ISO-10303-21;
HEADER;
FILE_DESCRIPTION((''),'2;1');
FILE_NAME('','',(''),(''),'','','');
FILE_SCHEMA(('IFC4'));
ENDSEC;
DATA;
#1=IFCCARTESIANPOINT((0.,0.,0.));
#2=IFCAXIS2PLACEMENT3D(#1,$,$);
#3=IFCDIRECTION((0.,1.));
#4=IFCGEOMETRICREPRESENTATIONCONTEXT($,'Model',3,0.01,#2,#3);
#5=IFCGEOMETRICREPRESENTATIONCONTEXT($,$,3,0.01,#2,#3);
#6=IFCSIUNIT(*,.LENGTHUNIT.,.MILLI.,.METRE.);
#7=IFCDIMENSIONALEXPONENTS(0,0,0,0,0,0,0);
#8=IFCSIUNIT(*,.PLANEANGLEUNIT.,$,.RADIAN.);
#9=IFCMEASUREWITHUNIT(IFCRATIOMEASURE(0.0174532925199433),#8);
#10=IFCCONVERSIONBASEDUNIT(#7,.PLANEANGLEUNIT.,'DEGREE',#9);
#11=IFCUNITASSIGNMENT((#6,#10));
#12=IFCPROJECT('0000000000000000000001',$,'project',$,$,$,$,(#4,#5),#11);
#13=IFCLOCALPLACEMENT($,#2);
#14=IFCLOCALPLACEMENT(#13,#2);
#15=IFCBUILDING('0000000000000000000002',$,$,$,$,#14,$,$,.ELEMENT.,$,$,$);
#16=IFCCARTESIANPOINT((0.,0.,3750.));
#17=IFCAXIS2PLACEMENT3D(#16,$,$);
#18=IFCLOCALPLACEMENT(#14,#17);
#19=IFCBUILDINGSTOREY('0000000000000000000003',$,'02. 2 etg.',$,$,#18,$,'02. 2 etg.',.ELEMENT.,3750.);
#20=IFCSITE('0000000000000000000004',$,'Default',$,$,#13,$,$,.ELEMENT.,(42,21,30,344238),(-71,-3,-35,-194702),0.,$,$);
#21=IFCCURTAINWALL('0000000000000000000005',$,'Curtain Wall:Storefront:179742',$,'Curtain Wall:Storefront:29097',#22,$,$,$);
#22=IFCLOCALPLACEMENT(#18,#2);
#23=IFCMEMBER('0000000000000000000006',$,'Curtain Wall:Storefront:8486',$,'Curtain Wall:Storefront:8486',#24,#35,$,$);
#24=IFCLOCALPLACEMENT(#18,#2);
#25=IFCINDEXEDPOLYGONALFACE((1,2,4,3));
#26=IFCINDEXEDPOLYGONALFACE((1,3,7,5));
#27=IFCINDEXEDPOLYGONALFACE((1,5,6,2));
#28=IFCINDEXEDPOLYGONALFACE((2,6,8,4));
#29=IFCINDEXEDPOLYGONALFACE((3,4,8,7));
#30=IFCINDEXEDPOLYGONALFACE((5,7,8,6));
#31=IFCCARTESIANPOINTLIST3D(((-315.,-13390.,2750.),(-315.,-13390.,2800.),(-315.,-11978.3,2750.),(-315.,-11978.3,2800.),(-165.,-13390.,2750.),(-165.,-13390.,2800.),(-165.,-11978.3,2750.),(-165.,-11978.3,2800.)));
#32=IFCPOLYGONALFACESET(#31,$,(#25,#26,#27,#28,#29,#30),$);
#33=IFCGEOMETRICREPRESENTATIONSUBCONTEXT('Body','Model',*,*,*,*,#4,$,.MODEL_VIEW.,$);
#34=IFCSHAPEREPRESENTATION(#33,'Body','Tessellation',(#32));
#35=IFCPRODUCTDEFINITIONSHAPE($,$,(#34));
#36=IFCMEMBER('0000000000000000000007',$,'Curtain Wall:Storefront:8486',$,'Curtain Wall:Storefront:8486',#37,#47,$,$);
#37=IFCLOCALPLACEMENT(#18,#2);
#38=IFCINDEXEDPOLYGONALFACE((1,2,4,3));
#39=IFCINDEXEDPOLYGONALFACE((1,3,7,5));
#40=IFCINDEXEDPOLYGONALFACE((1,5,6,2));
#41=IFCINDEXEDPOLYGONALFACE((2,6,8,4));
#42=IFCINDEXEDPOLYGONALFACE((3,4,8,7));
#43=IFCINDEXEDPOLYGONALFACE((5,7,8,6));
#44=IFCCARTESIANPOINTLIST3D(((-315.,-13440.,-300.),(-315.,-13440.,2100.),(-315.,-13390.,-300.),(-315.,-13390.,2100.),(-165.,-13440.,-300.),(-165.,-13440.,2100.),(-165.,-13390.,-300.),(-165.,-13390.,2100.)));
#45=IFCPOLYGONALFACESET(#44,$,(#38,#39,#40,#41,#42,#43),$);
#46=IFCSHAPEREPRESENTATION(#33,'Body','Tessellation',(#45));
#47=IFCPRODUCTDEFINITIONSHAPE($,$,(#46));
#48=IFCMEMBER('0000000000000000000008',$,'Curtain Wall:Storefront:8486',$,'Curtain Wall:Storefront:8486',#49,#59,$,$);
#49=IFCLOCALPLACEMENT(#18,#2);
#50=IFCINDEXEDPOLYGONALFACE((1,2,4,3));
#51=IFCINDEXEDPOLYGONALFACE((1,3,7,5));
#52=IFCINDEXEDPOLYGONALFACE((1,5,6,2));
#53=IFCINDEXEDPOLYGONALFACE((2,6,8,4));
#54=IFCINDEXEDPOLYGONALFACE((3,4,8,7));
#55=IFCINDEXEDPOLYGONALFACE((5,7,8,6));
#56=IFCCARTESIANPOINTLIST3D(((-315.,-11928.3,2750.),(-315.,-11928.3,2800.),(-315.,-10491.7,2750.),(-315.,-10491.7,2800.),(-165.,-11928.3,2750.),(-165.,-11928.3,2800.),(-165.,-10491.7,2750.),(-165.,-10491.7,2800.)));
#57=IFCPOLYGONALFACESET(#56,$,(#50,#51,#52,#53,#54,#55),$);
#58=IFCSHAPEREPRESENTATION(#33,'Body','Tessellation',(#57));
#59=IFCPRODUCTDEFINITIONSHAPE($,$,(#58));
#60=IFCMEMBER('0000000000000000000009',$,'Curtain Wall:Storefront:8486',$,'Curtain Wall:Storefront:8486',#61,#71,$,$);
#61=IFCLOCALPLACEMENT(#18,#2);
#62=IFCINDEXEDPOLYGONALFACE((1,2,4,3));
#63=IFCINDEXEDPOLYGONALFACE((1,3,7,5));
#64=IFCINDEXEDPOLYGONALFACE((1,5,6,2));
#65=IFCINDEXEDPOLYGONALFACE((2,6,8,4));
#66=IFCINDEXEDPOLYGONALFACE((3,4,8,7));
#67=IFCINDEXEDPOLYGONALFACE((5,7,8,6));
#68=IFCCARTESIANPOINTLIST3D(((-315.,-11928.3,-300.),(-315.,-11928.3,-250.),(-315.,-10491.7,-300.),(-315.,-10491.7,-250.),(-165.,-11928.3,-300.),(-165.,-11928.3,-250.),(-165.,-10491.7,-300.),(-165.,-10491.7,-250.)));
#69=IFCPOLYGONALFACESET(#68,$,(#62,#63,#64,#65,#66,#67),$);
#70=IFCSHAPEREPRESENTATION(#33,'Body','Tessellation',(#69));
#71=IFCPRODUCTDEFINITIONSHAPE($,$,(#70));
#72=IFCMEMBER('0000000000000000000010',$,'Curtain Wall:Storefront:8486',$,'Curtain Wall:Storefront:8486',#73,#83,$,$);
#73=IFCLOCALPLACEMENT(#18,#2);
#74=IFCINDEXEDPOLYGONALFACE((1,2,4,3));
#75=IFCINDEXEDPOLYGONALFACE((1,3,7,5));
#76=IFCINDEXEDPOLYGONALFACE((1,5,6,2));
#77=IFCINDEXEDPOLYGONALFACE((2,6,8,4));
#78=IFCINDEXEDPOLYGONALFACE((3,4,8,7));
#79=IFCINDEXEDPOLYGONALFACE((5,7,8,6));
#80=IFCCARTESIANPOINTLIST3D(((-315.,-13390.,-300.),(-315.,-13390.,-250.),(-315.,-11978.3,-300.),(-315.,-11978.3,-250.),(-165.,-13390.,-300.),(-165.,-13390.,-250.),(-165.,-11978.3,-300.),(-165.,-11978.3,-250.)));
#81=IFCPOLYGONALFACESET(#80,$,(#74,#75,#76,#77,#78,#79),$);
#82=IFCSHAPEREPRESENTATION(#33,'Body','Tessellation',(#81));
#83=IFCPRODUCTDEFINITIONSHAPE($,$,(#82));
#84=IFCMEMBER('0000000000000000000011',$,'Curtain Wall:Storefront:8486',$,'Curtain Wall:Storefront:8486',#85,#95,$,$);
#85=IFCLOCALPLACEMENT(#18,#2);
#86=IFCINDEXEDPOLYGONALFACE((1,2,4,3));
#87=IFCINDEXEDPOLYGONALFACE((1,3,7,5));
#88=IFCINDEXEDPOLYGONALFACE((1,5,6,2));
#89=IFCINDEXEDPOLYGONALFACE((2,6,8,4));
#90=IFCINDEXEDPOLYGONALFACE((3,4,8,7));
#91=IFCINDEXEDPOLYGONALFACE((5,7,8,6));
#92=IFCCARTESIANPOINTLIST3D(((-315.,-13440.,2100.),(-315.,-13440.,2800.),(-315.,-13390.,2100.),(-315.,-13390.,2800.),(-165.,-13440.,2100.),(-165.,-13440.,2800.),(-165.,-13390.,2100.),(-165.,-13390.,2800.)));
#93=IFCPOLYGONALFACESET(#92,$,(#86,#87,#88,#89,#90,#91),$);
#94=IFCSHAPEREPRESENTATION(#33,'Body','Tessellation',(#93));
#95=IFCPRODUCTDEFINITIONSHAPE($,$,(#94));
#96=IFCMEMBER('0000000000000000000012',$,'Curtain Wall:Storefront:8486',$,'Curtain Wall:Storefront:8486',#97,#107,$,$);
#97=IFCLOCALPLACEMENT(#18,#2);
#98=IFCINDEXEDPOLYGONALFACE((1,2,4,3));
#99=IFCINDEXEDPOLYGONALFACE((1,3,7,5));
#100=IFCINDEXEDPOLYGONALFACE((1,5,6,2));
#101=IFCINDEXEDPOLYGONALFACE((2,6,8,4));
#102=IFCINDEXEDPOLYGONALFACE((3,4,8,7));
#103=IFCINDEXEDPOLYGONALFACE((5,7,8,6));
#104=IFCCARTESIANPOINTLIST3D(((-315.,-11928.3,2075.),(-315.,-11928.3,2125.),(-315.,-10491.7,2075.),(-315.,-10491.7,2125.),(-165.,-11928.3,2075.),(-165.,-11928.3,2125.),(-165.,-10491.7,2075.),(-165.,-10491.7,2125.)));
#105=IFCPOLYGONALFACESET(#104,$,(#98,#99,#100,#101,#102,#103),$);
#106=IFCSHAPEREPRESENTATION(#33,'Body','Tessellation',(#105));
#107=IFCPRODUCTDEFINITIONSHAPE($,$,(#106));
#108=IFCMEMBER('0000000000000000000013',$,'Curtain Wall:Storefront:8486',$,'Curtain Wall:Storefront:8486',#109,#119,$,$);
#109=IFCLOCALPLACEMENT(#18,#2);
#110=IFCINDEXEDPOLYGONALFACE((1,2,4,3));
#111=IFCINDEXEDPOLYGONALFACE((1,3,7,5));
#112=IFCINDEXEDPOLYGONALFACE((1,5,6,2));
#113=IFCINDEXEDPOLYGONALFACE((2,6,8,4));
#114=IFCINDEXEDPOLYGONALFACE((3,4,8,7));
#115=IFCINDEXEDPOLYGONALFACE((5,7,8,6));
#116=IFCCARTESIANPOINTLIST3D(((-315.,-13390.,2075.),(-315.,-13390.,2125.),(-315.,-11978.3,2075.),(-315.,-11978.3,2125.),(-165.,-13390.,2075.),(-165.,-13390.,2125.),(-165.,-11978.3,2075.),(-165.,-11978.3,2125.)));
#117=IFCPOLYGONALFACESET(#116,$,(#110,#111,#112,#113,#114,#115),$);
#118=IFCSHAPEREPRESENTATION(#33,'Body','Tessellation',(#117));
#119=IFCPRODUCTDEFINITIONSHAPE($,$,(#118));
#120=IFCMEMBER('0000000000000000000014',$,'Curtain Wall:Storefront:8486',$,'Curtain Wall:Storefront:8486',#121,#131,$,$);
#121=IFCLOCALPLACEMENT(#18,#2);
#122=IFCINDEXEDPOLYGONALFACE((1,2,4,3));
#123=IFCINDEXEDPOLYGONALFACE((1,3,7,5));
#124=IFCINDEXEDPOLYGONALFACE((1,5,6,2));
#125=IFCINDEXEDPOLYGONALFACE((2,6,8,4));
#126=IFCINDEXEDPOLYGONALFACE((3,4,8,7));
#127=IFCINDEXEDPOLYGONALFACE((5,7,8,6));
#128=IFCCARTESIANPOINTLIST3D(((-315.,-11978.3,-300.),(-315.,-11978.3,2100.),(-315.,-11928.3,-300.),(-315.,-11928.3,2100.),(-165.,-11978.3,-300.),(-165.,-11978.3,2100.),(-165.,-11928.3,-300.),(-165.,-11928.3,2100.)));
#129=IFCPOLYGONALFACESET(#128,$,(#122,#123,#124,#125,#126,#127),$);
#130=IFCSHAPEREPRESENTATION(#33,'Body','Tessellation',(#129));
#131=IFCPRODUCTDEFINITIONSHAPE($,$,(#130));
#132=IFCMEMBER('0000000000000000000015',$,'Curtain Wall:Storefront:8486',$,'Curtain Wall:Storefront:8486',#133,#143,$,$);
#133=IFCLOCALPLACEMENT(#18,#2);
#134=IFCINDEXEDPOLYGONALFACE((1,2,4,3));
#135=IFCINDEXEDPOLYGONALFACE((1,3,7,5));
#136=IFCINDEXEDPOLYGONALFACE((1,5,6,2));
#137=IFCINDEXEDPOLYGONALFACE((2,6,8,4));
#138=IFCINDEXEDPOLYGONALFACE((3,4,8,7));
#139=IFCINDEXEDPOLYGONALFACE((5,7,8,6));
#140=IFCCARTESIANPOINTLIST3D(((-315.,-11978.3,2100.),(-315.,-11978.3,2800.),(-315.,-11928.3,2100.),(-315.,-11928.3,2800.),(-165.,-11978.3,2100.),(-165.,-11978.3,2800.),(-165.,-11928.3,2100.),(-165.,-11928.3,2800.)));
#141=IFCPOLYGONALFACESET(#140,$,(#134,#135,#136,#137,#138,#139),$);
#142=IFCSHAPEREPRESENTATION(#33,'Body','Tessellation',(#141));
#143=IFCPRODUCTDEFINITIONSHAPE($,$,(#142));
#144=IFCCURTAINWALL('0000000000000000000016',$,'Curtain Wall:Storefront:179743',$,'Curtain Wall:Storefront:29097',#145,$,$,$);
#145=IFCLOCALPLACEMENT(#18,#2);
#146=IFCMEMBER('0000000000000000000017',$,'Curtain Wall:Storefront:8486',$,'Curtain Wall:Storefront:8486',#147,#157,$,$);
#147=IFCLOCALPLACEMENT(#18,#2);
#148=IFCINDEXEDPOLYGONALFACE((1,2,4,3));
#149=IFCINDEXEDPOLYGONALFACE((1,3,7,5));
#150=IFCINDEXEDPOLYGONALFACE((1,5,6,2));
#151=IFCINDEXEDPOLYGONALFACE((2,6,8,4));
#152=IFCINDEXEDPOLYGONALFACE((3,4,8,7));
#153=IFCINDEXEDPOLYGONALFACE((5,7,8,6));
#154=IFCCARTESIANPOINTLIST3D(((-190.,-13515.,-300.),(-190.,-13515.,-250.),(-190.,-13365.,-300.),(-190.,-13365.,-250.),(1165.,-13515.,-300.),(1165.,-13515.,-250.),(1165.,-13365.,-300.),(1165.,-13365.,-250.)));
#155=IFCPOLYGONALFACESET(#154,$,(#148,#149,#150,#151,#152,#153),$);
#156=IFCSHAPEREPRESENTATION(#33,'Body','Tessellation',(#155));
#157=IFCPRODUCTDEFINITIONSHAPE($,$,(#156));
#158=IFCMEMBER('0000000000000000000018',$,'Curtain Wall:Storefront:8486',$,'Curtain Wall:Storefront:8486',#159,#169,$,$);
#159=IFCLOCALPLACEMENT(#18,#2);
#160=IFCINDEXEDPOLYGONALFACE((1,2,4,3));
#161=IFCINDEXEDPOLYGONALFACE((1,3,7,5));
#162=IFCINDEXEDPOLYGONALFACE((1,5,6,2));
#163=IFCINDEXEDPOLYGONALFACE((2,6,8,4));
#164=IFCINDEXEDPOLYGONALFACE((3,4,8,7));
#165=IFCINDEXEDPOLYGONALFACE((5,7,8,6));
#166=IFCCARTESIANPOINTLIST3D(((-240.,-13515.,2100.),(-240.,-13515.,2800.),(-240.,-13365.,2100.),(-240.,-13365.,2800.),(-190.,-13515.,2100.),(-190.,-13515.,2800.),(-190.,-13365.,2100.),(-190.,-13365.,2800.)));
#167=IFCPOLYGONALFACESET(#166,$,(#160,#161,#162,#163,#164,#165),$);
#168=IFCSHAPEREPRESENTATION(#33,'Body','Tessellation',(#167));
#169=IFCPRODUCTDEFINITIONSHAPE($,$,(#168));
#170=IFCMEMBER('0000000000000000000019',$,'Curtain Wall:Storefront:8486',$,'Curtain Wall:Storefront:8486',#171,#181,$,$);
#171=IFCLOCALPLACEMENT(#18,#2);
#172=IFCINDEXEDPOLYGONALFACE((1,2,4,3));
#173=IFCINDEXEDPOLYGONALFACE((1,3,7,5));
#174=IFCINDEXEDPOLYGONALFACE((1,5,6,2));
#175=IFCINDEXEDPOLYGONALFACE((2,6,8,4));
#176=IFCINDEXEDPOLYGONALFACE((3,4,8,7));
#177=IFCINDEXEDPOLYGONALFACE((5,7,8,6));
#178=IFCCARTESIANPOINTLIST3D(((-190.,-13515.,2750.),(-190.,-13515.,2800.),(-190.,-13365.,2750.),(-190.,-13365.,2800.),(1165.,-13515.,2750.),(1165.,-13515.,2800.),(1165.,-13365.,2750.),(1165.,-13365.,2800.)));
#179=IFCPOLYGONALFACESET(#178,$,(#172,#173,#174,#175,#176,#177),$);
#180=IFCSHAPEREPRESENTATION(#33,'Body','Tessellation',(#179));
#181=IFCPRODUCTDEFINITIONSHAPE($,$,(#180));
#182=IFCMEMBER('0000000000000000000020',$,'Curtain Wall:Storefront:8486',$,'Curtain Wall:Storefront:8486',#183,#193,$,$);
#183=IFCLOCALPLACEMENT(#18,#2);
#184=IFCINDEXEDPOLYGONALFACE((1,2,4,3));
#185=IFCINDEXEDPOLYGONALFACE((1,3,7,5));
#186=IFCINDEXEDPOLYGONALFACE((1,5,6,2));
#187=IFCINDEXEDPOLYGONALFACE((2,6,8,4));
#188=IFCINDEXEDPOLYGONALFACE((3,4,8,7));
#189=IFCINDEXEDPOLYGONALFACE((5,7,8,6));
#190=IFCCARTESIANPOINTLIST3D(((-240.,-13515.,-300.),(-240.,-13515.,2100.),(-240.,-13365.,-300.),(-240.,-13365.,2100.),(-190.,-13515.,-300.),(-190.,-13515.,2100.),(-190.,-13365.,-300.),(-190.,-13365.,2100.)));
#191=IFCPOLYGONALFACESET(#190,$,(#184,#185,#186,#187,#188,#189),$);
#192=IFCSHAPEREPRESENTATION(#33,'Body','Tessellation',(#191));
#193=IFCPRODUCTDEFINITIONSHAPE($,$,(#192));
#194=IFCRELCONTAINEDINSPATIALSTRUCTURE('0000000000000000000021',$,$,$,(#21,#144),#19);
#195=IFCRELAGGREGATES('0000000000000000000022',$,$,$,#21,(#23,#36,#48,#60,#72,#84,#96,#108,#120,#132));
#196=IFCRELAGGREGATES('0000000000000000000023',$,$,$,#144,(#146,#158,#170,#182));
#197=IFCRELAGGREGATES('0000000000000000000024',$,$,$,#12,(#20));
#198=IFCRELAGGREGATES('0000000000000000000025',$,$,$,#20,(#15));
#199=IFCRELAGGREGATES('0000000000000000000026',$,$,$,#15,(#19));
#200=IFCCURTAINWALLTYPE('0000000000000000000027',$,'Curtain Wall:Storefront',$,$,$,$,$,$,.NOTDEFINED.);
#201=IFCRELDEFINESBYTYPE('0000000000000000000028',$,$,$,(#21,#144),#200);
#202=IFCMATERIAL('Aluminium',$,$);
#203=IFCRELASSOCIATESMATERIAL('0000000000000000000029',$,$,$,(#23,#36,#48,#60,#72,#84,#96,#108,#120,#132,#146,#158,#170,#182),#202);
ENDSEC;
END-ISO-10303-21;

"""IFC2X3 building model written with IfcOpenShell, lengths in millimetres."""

from ifc_helpers import new_model, entity, si_unit, converted_unit, direction, frame, frame_2d, origin, origin_2d_with_axis, place, context, subcontext, project, spatial, rectangle, extrude, material, type_object, element, aggregate, save


model = new_model("IFC2X3")

# Units and contexts
model_context = context("Model", 3, precision=0.01, world=origin(), true_north=direction((0.0, 1.0)))
context_of_model = context(None, 3, precision=0.01, world=origin(), true_north=direction((0.0, 1.0)))
body_context = subcontext(model_context, "Body", "Model", "MODEL_VIEW")
ifc_project = project(units=[si_unit("LENGTHUNIT", "METRE", prefix="MILLI"), converted_unit("PLANEANGLEUNIT", "DEGREE", entity("IfcRatioMeasure", 0.0174532925199433), si_unit("PLANEANGLEUNIT", "RADIAN"), dimensions=[0, 0, 0, 0, 0, 0, 0])], contexts=[model_context, context_of_model])

# Site, building, storey
site_placement = place(None, origin())
site = spatial("IfcSite", under=ifc_project, at=site_placement, Name="Default", CompositionType="ELEMENT", RefLatitude=(42, 21, 30, 344238), RefLongitude=(-71, -3, -35, -194702), RefElevation=0.0)
building_placement = place(site_placement, origin())
building = spatial("IfcBuilding", under=site, at=building_placement, CompositionType="ELEMENT")
storey_placement = place(building_placement, frame((0.0, 0.0, 3750.0)))
storey = spatial("IfcBuildingStorey", under=building, at=storey_placement, Name="02. 2 etg.", LongName="02. 2 etg.", CompositionType="ELEMENT", Elevation=3750.0)

# Curtain walls, members
curtain_wall_type = type_object("IfcCurtainWallType", Name="Curtain Wall:Storefront", PredefinedType="NOTDEFINED")
curtain_wall_1_placement = place(storey_placement, frame((0.0, 0.0, -3750.0)))
curtain_wall_1 = element("IfcCurtainWall", 1, at=curtain_wall_1_placement, inside=storey, type_object=curtain_wall_type, Name="Curtain Wall:Storefront:179742", ObjectType="Curtain Wall:Storefront:29097")
ifc_material_1 = material(Name="Aluminium")
member_1_placement = place(curtain_wall_1_placement, frame((-315.0, -13390.0, 6500.0)))
member_1 = element("IfcMember", 2, at=member_1_placement, material=ifc_material_1, Name="Curtain Wall:Storefront:8486", ObjectType="Curtain Wall:Storefront:8486", context=body_context, shape_type="SweptSolid", body=[
    extrude(rectangle(XDim=1411.7, YDim=150.0, at=frame_2d((0.0, 0.0), x_axis=(1.0, 0.0))), frame((75.0, 705.8, 0.0), z_axis=(0.0, 0.0, 1.0), x_axis=(0.0, 1.0, 0.0)), (0.0, 0.0, 1.0), 50.0),
])
member_2_placement = place(curtain_wall_1_placement, frame((-315.0, -13440.0, 3450.0)))
member_2 = element("IfcMember", 3, at=member_2_placement, material=ifc_material_1, Name="Curtain Wall:Storefront:8486", ObjectType="Curtain Wall:Storefront:8486", context=body_context, shape_type="SweptSolid", body=[
    extrude(rectangle(XDim=150.0, YDim=50.0, at=frame_2d((0.0, 0.0), x_axis=(1.0, 0.0))), frame((75.0, 25.0, 0.0)), (0.0, 0.0, 1.0), 2400.0),
])
member_3_placement = place(curtain_wall_1_placement, frame((-315.0, -11928.3, 6500.0)))
member_3 = element("IfcMember", 4, at=member_3_placement, material=ifc_material_1, Name="Curtain Wall:Storefront:8486", ObjectType="Curtain Wall:Storefront:8486", context=body_context, shape_type="SweptSolid", body=[
    extrude(rectangle(XDim=1436.7, YDim=150.0, at=origin_2d_with_axis()), frame((75.0, 718.3, 0.0), z_axis=(0.0, 0.0, 1.0), x_axis=(0.0, 1.0, 0.0)), (0.0, 0.0, 1.0), 50.0),
])
member_4_placement = place(curtain_wall_1_placement, frame((-315.0, -11928.3, 3450.0)))
member_4 = element("IfcMember", 5, at=member_4_placement, material=ifc_material_1, Name="Curtain Wall:Storefront:8486", ObjectType="Curtain Wall:Storefront:8486", context=body_context, shape_type="SweptSolid", body=[
    extrude(rectangle(XDim=1436.7, YDim=150.0, at=frame_2d((0.0, 0.0), x_axis=(1.0, 0.0))), frame((75.0, 718.3, 0.0), z_axis=(0.0, 0.0, 1.0), x_axis=(0.0, -1.0, 0.0)), (0.0, 0.0, 1.0), 50.0),
])
member_5_placement = place(curtain_wall_1_placement, frame((-315.0, -13390.0, 3450.0)))
member_5 = element("IfcMember", 6, at=member_5_placement, material=ifc_material_1, Name="Curtain Wall:Storefront:8486", ObjectType="Curtain Wall:Storefront:8486", context=body_context, shape_type="SweptSolid", body=[
    extrude(rectangle(XDim=1411.7, YDim=150.0, at=frame_2d((0.0, 0.0), x_axis=(1.0, 0.0))), frame((75.0, 705.8, 0.0), z_axis=(0.0, 0.0, 1.0), x_axis=(0.0, -1.0, 0.0)), (0.0, 0.0, 1.0), 50.0),
])
member_6_placement = place(curtain_wall_1_placement, frame((-315.0, -13440.0, 5850.0)))
member_6 = element("IfcMember", 7, at=member_6_placement, material=ifc_material_1, Name="Curtain Wall:Storefront:8486", ObjectType="Curtain Wall:Storefront:8486", context=body_context, shape_type="SweptSolid", body=[
    extrude(rectangle(XDim=150.0, YDim=50.0, at=frame_2d((0.0, 0.0), x_axis=(1.0, 0.0))), frame((75.0, 25.0, 0.0)), (0.0, 0.0, 1.0), 700.0),
])
member_7_placement = place(curtain_wall_1_placement, frame((-315.0, -11928.3, 5825.0)))
member_7 = element("IfcMember", 8, at=member_7_placement, material=ifc_material_1, Name="Curtain Wall:Storefront:8486", ObjectType="Curtain Wall:Storefront:8486", context=body_context, shape_type="SweptSolid", body=[
    extrude(rectangle(XDim=1436.7, YDim=150.0, at=origin_2d_with_axis()), frame((75.0, 718.3, 0.0), z_axis=(0.0, 0.0, 1.0), x_axis=(0.0, 1.0, 0.0)), (0.0, 0.0, 1.0), 50.0),
])
member_8_placement = place(curtain_wall_1_placement, frame((-315.0, -13390.0, 5825.0)))
member_8 = element("IfcMember", 9, at=member_8_placement, material=ifc_material_1, Name="Curtain Wall:Storefront:8486", ObjectType="Curtain Wall:Storefront:8486", context=body_context, shape_type="SweptSolid", body=[
    extrude(rectangle(XDim=1411.7, YDim=150.0, at=frame_2d((0.0, 0.0), x_axis=(1.0, 0.0))), frame((75.0, 705.8, 0.0), z_axis=(0.0, 0.0, 1.0), x_axis=(0.0, 1.0, 0.0)), (0.0, 0.0, 1.0), 50.0),
])
member_9_placement = place(curtain_wall_1_placement, frame((-315.0, -11978.3, 3450.0)))
member_9 = element("IfcMember", 10, at=member_9_placement, material=ifc_material_1, Name="Curtain Wall:Storefront:8486", ObjectType="Curtain Wall:Storefront:8486", context=body_context, shape_type="SweptSolid", body=[
    extrude(rectangle(XDim=150.0, YDim=50.0, at=frame_2d((0.0, 0.0), x_axis=(1.0, 0.0))), frame((75.0, 25.0, 0.0)), (0.0, 0.0, 1.0), 2400.0),
])
member_10_placement = place(curtain_wall_1_placement, frame((-315.0, -11978.3, 5850.0)))
member_10 = element("IfcMember", 11, at=member_10_placement, material=ifc_material_1, Name="Curtain Wall:Storefront:8486", ObjectType="Curtain Wall:Storefront:8486", context=body_context, shape_type="SweptSolid", body=[
    extrude(rectangle(XDim=150.0, YDim=50.0, at=frame_2d((0.0, 0.0), x_axis=(1.0, 0.0))), frame((75.0, 25.0, 0.0)), (0.0, 0.0, 1.0), 700.0),
])
curtain_wall_2_placement = place(storey_placement, frame((0.0, 0.0, -3750.0)))
curtain_wall_2 = element("IfcCurtainWall", 12, at=curtain_wall_2_placement, inside=storey, type_object=curtain_wall_type, Name="Curtain Wall:Storefront:179743", ObjectType="Curtain Wall:Storefront:29097")
member_11_placement = place(curtain_wall_2_placement, frame((-190.0, -13515.0, 3450.0)))
member_11 = element("IfcMember", 13, at=member_11_placement, material=ifc_material_1, Name="Curtain Wall:Storefront:8486", ObjectType="Curtain Wall:Storefront:8486", context=body_context, shape_type="SweptSolid", body=[
    extrude(rectangle(XDim=1355.0, YDim=150.0, at=frame_2d((0.0, 0.0), x_axis=(1.0, 0.0))), frame((677.5, 75.0, 0.0)), (0.0, 0.0, 1.0), 50.0),
])
member_12_placement = place(curtain_wall_2_placement, frame((-240.0, -13515.0, 5850.0)))
member_12 = element("IfcMember", 14, at=member_12_placement, material=ifc_material_1, Name="Curtain Wall:Storefront:8486", ObjectType="Curtain Wall:Storefront:8486", context=body_context, shape_type="SweptSolid", body=[
    extrude(rectangle(XDim=50.0, YDim=150.0, at=frame_2d((0.0, 0.0), x_axis=(1.0, 0.0))), frame((25.0, 75.0, 0.0)), (0.0, 0.0, 1.0), 700.0),
])
member_13_placement = place(curtain_wall_2_placement, frame((-190.0, -13515.0, 6500.0)))
member_13 = element("IfcMember", 15, at=member_13_placement, material=ifc_material_1, Name="Curtain Wall:Storefront:8486", ObjectType="Curtain Wall:Storefront:8486", context=body_context, shape_type="SweptSolid", body=[
    extrude(rectangle(XDim=1355.0, YDim=150.0, at=origin_2d_with_axis()), frame((677.5, 75.0, 0.0), z_axis=(0.0, 0.0, 1.0), x_axis=(-1.0, 0.0, 0.0)), (0.0, 0.0, 1.0), 50.0),
])
member_14_placement = place(curtain_wall_2_placement, frame((-240.0, -13515.0, 3450.0)))
member_14 = element("IfcMember", 16, at=member_14_placement, material=ifc_material_1, Name="Curtain Wall:Storefront:8486", ObjectType="Curtain Wall:Storefront:8486", context=body_context, shape_type="SweptSolid", body=[
    extrude(rectangle(XDim=50.0, YDim=150.0, at=frame_2d((0.0, 0.0), x_axis=(1.0, 0.0))), frame((25.0, 75.0, 0.0)), (0.0, 0.0, 1.0), 2400.0),
])

aggregate(curtain_wall_1, [member_1, member_2, member_3, member_4, member_5, member_6, member_7, member_8, member_9, member_10])
aggregate(curtain_wall_2, [member_11, member_12, member_13, member_14])

save(model, "model.ifc")
